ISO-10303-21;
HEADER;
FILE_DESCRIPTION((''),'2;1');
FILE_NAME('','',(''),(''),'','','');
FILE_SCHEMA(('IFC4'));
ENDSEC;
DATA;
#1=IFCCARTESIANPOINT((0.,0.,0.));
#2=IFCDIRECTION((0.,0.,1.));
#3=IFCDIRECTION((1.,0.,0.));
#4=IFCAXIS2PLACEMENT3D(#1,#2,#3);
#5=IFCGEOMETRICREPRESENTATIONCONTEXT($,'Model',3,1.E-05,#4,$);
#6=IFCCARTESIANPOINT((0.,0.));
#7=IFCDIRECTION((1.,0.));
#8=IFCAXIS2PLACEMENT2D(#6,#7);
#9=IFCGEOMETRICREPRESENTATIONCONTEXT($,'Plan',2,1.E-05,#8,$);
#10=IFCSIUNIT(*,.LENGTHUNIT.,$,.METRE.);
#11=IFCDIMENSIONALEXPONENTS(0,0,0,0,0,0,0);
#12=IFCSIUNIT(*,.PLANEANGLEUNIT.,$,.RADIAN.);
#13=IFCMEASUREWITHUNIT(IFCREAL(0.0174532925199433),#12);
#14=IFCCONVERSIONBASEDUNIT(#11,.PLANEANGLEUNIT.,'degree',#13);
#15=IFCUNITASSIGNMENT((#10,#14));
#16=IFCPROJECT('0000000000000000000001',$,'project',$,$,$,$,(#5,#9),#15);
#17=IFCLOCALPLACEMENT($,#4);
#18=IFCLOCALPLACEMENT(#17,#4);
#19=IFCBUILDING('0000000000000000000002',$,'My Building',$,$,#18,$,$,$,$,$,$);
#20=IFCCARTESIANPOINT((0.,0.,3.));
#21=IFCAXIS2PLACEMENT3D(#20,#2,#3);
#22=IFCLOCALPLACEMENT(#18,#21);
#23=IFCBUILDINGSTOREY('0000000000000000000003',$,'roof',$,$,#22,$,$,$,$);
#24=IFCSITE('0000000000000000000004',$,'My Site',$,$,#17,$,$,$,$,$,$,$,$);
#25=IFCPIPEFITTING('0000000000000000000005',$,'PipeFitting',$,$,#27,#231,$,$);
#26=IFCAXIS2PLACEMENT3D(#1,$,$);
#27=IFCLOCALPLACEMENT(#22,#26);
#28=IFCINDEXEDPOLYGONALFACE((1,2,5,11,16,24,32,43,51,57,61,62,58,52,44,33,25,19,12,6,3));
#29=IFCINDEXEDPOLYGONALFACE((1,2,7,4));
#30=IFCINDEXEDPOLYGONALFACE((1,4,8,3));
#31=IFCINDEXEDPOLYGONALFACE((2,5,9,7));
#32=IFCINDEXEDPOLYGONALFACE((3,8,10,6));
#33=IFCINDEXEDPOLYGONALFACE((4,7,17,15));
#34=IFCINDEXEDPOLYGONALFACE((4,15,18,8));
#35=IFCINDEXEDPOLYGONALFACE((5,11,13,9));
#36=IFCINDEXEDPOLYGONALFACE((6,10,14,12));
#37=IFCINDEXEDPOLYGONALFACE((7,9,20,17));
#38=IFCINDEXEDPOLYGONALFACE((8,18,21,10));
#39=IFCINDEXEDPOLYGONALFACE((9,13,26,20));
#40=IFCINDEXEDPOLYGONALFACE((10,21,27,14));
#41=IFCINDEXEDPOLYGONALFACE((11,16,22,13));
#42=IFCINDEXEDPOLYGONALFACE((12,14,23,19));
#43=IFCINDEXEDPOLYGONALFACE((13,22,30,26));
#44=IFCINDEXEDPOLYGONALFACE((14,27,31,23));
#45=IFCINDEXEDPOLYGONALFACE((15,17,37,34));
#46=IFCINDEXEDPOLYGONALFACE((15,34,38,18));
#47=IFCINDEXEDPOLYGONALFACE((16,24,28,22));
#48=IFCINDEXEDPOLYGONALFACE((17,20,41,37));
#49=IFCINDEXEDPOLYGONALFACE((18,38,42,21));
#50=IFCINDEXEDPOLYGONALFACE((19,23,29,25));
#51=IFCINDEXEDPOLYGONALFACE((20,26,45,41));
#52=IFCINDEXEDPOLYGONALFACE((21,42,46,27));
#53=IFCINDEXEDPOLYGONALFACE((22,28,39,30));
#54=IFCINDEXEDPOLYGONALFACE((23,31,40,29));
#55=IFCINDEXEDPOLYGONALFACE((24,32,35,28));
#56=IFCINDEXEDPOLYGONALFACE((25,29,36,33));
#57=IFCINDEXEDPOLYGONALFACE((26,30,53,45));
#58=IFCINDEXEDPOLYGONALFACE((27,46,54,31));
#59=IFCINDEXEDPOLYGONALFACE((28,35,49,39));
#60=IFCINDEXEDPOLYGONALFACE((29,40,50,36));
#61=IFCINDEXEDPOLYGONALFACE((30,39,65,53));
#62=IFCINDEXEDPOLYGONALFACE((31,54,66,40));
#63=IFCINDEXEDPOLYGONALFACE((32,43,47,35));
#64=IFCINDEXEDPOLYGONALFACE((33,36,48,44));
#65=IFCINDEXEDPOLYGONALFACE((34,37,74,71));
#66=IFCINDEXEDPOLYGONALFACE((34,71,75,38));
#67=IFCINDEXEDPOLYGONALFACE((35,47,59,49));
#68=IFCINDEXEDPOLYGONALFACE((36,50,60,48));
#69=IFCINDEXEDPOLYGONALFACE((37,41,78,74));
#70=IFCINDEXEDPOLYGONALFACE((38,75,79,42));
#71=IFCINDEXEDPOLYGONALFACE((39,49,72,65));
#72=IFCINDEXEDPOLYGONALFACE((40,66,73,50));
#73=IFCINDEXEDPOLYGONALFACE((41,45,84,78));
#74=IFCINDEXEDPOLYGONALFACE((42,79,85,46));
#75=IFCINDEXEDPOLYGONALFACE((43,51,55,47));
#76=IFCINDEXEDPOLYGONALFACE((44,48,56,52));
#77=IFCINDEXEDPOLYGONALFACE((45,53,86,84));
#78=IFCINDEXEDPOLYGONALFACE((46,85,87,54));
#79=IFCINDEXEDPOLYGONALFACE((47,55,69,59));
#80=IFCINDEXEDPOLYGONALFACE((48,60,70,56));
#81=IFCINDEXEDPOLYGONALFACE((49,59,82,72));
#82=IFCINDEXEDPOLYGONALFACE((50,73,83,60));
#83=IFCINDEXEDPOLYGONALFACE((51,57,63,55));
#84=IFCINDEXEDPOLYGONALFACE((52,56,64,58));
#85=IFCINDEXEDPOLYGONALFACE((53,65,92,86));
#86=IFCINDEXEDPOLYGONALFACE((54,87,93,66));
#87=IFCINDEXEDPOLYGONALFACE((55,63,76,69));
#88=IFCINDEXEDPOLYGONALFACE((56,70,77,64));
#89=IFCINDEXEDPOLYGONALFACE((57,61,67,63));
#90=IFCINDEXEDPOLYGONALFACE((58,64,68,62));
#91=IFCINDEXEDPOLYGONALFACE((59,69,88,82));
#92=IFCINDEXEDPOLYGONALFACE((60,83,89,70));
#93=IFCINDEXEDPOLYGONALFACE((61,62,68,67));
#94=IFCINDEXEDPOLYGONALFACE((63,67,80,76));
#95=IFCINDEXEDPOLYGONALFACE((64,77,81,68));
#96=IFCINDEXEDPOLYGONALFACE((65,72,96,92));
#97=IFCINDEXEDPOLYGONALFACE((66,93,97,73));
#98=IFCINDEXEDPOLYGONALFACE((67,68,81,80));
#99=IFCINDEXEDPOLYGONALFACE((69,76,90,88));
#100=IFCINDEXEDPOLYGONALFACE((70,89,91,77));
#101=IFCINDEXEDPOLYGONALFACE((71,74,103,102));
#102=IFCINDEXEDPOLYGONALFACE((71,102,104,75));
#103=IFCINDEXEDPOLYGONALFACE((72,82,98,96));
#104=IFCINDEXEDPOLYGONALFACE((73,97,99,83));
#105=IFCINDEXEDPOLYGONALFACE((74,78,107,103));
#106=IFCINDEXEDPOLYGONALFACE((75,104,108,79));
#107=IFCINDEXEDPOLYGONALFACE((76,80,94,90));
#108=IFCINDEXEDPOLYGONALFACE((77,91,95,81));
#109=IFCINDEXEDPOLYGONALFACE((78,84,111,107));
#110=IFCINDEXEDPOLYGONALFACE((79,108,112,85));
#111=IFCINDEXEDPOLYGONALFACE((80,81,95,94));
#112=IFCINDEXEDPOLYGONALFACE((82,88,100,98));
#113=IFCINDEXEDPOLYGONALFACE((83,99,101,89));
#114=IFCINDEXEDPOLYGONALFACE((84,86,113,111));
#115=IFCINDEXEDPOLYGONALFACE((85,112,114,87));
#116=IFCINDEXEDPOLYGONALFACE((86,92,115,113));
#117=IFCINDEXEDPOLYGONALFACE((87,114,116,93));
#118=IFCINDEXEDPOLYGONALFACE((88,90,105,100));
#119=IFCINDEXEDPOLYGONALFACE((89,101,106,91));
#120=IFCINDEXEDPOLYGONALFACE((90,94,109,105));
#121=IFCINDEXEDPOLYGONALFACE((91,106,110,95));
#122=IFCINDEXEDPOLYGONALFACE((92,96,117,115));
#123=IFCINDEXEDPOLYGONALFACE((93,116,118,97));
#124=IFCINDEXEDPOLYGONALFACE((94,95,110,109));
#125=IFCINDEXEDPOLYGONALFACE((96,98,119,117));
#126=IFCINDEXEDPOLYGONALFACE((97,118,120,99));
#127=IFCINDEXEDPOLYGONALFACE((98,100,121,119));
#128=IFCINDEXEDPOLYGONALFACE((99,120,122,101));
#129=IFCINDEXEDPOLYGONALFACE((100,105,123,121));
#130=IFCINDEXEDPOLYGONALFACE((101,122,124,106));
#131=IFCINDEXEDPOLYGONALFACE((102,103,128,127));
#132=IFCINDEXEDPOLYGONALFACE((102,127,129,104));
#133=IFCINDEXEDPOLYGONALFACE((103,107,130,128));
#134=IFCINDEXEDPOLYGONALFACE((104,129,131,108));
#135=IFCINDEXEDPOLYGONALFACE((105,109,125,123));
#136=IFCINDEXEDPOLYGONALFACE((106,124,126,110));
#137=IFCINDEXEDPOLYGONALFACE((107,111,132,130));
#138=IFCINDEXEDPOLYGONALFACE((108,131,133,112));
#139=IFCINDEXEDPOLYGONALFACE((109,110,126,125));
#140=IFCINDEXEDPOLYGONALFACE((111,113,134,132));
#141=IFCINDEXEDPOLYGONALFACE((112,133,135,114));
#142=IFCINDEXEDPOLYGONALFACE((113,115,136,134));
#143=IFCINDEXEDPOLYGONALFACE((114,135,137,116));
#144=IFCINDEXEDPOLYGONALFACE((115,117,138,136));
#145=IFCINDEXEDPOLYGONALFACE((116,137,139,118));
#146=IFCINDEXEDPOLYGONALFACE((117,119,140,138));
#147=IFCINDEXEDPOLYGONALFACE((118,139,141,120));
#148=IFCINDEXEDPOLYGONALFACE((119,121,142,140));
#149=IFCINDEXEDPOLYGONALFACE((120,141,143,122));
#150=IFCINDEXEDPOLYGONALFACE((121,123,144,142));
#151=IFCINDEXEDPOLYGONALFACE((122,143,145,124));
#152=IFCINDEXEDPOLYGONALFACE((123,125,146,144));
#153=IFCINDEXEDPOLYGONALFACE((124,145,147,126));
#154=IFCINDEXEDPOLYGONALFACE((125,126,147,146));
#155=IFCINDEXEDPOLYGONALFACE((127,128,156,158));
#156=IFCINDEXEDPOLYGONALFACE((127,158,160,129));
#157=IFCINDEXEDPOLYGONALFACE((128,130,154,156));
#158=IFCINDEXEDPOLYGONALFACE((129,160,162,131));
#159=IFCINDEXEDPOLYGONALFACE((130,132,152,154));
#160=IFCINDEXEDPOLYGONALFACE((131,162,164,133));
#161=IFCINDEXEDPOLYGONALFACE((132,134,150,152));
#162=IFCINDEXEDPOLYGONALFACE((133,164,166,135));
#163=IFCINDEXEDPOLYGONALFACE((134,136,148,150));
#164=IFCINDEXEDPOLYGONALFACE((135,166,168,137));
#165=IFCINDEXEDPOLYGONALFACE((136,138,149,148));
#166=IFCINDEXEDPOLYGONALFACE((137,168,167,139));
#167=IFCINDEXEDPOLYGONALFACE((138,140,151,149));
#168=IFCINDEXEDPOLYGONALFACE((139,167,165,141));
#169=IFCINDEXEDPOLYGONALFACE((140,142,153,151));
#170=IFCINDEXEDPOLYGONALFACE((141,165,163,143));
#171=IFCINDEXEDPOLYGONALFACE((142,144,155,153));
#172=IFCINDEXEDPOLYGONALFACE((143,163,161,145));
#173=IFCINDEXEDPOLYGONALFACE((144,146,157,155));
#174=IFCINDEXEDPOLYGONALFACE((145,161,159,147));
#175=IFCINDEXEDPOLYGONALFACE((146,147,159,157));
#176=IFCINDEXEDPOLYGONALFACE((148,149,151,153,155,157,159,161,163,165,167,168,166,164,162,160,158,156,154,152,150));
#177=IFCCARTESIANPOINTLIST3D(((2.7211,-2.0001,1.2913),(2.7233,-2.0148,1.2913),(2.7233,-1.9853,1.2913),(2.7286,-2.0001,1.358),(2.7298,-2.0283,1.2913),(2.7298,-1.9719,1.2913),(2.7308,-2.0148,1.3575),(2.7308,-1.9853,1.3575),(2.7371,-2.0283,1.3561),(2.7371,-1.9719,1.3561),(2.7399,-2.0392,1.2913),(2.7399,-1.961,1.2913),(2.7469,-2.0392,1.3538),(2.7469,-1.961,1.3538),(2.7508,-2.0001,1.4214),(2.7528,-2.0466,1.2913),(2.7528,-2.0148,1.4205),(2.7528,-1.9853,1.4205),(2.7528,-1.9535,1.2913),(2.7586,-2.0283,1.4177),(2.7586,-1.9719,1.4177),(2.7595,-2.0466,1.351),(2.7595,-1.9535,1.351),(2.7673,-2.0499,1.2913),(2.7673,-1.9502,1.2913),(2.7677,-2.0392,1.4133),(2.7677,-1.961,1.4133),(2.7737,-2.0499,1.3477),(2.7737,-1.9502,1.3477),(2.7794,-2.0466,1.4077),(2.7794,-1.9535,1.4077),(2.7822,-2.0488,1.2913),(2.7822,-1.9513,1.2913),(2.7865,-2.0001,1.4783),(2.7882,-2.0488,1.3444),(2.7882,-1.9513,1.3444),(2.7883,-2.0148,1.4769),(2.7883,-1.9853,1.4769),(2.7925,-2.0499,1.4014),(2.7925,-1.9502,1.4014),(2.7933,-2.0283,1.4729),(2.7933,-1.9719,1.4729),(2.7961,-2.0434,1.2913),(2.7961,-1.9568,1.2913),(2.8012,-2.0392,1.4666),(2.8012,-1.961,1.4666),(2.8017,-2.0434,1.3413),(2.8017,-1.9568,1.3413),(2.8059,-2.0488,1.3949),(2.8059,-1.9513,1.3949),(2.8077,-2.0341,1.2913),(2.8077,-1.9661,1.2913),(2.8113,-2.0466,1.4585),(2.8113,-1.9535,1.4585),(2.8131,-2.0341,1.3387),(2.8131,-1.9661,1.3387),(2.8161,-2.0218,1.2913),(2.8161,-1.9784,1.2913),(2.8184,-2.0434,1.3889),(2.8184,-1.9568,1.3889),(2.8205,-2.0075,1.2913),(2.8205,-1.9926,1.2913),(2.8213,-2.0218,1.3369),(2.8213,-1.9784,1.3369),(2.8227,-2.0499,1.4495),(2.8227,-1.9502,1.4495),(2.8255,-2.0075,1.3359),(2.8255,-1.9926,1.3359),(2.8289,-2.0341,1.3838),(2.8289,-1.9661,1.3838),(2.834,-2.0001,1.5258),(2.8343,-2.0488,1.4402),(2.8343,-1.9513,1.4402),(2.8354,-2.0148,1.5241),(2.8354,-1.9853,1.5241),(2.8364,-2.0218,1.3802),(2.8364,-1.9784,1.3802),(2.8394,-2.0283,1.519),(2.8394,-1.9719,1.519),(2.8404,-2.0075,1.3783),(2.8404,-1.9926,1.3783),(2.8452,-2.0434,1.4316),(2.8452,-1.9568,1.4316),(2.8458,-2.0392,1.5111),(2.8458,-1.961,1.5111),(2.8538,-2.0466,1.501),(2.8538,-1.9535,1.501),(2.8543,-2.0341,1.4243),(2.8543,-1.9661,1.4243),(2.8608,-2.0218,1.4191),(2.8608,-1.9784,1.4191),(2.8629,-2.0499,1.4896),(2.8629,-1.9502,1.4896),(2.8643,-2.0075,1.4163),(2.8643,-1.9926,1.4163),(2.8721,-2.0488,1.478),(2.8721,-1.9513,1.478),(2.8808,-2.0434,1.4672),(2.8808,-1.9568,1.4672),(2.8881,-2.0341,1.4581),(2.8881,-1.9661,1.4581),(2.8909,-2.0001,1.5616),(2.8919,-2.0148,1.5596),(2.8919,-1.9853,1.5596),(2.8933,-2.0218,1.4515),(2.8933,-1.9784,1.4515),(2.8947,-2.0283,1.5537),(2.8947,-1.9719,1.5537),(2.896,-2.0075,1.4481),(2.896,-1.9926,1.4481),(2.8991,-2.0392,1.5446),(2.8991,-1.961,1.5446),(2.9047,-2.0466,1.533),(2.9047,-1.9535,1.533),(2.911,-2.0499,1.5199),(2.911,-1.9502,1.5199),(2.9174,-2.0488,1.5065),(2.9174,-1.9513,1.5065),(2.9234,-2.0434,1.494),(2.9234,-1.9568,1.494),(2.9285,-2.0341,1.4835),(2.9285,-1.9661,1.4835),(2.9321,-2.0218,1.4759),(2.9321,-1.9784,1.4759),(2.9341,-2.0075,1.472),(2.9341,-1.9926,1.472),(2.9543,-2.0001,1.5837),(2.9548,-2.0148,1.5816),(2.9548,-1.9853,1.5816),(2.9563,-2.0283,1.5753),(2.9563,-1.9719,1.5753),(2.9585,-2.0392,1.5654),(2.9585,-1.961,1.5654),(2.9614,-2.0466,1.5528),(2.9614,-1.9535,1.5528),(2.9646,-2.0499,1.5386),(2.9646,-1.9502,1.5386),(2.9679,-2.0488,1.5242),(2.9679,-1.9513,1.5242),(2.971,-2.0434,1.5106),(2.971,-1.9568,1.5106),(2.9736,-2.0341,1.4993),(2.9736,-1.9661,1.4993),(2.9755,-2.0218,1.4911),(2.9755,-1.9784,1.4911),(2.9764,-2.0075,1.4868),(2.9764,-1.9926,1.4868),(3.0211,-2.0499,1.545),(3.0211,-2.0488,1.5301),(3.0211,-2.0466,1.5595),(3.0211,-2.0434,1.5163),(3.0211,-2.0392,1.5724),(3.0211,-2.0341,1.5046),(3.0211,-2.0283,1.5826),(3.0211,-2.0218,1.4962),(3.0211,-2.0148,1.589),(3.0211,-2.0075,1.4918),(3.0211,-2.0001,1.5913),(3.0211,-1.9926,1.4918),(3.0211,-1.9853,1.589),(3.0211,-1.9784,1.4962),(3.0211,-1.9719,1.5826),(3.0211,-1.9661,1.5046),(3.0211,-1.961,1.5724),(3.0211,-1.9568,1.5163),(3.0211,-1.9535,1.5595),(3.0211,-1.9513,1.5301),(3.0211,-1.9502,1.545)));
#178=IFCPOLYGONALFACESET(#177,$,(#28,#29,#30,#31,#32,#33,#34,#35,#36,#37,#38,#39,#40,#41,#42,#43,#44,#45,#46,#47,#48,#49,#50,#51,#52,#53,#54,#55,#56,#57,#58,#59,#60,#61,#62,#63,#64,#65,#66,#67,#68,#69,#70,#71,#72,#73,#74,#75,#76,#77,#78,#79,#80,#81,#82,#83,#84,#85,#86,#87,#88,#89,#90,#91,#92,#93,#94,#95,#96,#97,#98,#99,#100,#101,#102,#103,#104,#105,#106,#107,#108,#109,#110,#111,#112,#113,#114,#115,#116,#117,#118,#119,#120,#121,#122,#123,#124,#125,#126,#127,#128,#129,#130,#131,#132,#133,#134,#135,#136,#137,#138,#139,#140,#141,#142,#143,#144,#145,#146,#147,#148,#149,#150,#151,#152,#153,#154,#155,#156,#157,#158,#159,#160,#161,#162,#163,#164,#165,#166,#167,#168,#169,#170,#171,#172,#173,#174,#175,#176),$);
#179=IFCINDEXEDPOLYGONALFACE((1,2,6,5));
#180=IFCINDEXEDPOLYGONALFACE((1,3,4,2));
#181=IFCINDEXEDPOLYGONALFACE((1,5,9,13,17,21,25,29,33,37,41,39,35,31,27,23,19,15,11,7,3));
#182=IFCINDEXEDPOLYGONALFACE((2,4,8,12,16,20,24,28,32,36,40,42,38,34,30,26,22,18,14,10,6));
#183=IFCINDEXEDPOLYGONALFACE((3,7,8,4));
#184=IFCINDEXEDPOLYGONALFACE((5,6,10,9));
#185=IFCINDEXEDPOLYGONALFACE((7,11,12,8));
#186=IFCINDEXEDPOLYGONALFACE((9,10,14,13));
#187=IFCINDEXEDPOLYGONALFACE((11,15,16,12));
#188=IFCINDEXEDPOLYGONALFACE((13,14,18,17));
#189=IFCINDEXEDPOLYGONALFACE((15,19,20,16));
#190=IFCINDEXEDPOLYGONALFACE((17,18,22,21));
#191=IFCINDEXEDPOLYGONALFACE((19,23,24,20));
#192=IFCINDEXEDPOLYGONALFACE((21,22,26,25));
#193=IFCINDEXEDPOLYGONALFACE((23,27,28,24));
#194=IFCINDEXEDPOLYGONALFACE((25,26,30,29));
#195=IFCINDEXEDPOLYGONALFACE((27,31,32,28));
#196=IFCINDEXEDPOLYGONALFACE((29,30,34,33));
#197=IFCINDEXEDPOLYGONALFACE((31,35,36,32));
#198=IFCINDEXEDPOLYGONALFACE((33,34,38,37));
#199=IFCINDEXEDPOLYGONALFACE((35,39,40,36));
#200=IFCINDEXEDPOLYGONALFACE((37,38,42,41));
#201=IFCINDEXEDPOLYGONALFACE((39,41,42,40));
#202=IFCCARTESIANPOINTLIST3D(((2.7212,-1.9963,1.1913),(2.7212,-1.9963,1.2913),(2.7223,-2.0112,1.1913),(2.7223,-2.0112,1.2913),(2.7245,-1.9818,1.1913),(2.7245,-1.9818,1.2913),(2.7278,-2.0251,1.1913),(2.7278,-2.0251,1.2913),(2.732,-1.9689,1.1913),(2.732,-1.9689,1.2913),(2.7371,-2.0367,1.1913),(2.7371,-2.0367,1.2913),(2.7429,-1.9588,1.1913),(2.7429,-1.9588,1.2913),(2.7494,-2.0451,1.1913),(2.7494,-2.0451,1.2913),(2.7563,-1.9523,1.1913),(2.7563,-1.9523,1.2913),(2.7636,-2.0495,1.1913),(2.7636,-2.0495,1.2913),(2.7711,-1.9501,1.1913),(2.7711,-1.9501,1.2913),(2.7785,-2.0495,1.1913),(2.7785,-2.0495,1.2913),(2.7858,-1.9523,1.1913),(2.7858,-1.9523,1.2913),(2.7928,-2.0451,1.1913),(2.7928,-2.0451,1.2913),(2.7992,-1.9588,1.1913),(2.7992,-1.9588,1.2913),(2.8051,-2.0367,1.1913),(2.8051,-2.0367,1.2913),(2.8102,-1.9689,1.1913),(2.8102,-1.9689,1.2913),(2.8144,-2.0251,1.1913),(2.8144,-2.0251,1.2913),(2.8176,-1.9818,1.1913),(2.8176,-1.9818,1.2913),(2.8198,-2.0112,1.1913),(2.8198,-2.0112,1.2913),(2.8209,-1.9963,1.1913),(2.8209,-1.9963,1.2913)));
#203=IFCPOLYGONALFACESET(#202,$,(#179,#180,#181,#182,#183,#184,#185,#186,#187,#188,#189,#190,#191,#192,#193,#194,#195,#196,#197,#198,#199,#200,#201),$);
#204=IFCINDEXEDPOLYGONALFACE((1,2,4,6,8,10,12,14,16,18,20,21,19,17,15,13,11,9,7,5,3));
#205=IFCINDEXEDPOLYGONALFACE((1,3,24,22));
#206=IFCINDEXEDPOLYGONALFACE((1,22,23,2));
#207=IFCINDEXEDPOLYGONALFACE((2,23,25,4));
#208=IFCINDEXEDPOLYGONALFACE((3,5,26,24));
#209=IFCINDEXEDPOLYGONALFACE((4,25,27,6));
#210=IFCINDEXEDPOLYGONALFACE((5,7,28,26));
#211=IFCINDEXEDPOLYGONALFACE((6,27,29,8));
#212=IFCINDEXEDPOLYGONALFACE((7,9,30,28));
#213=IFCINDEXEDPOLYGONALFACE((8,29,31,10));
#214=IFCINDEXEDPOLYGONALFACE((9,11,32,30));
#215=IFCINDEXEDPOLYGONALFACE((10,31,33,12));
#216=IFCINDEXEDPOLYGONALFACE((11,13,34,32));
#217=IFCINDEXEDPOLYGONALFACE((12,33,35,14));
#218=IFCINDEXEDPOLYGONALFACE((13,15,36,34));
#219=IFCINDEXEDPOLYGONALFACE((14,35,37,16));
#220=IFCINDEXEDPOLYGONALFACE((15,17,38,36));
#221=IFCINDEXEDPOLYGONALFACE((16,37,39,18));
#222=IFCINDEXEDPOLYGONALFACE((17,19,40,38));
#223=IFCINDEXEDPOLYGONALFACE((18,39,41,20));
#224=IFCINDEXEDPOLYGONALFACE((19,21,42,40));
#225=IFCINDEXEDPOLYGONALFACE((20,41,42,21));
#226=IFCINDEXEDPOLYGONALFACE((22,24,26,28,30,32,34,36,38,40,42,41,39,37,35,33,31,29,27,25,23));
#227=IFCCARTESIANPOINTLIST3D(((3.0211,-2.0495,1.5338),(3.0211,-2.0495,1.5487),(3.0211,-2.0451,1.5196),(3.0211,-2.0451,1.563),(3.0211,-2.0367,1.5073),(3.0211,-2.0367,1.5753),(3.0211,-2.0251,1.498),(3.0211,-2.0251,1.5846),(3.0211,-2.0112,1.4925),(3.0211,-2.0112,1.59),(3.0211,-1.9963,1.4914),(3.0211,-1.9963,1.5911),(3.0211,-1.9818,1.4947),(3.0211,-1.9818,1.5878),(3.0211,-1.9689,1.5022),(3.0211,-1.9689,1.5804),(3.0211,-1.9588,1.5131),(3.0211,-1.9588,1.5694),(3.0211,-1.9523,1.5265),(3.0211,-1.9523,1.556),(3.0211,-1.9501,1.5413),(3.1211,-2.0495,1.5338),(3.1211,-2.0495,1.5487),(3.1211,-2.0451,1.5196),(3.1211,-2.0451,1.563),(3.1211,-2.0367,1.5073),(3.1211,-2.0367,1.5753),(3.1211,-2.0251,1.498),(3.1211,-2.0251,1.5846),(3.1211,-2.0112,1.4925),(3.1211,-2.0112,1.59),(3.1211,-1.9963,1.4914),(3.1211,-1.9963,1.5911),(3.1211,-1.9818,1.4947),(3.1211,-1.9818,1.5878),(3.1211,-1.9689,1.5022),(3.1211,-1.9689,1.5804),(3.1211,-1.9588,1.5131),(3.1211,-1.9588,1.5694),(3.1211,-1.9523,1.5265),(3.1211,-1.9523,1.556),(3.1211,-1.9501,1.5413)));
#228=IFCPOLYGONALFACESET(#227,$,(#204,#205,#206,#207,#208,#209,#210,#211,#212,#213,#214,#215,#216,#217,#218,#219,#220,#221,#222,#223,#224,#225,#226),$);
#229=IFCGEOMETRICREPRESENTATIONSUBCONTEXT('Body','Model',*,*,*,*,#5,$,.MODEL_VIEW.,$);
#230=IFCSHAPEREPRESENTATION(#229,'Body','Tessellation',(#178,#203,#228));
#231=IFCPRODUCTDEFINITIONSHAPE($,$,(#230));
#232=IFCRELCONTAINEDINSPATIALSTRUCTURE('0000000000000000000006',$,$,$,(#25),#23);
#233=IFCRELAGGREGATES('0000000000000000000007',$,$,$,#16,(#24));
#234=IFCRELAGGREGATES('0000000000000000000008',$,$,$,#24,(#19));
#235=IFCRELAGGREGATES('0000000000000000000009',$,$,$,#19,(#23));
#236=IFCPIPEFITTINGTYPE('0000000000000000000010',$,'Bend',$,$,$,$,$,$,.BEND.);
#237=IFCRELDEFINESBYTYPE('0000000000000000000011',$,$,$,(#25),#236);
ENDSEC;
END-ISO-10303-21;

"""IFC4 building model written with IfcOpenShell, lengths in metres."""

from ifc_helpers import new_model, entity, si_unit, converted_unit, frame, origin_with_axes, origin_2d_with_axis, place, context, subcontext, project, spatial, circle, extrude, source, transform, mapped, type_object, type_shapes, element, save


model = new_model("IFC4")

# Units and contexts
model_context = context("Model", 3, precision=1e-05, world=origin_with_axes())
plan_context = context("Plan", 2, precision=1e-05, world=origin_2d_with_axis())
body_context = subcontext(model_context, "Body", "Model", "MODEL_VIEW")
ifc_project = project(units=[si_unit("LENGTHUNIT", "METRE"), converted_unit("PLANEANGLEUNIT", "degree", entity("IfcReal", 0.0174532925199433), si_unit("PLANEANGLEUNIT", "RADIAN"), dimensions=[0, 0, 0, 0, 0, 0, 0])], contexts=[model_context, plan_context])

# Site, building, storey
site_placement = place(None, origin_with_axes())
site = spatial("IfcSite", under=ifc_project, at=site_placement, Name="My Site")
building_placement = place(site_placement, origin_with_axes())
building = spatial("IfcBuilding", under=site, at=building_placement, Name="My Building")
storey_placement = place(building_placement, frame((0.0, 0.0, 3.0), z_axis=(0.0, 0.0, 1.0), x_axis=(1.0, 0.0, 0.0)))
storey = spatial("IfcBuildingStorey", under=building, at=storey_placement, Name="roof")

# Pipe fitting
pipe_fitting_type_1 = type_object("IfcPipeFittingType", Name="Bend", PredefinedType="BEND")
shared_shape = source(origin_with_axes(), body_context, "Body", "SolidModel", [
    entity("IfcSweptDiskSolid", entity("IfcIndexedPolyCurve", entity("IfcCartesianPointList3D", [[0.0, 0.0, 0.1], [0.0, -0.0732, 0.2768], [0.0, -0.25, 0.35]]), [entity("IfcArcIndex", [1, 2, 3])]), 0.05),
    extrude(circle(Radius=0.05), origin_with_axes(), (0.0, 0.0, 1.0), 0.1),
    extrude(circle(Radius=0.05), frame((0.0, -0.25, 0.35), z_axis=(0.0, -1.0, 0.0), x_axis=(1.0, 0.0, 0.0)), (0.0, 0.0, 1.0), 0.1),
])
type_shapes(pipe_fitting_type_1, [shared_shape])
for number, where, z_axis, x_axis, name in (
    (1, (2.7711, -2.0001, 1.1913), (-0.000001, 0.000001, 1.0), (0.0, 1.0, -0.000001), "PipeFitting"),
):
    element("IfcPipeFitting", number, at=place(storey_placement, frame(where, z_axis=z_axis, x_axis=x_axis)), inside=storey, type_object=pipe_fitting_type_1, Name=name, context=body_context, shape_type="MappedRepresentation", body=[
        mapped(shared_shape, transform((0.0, 0.0, 0.0), x_axis=(1.0, 0.0, 0.0), y_axis=(0.0, 1.0, 0.0), z_axis=(0.0, 0.0, 1.0), scale=1.0)),
    ])

save(model, "model.ifc")
